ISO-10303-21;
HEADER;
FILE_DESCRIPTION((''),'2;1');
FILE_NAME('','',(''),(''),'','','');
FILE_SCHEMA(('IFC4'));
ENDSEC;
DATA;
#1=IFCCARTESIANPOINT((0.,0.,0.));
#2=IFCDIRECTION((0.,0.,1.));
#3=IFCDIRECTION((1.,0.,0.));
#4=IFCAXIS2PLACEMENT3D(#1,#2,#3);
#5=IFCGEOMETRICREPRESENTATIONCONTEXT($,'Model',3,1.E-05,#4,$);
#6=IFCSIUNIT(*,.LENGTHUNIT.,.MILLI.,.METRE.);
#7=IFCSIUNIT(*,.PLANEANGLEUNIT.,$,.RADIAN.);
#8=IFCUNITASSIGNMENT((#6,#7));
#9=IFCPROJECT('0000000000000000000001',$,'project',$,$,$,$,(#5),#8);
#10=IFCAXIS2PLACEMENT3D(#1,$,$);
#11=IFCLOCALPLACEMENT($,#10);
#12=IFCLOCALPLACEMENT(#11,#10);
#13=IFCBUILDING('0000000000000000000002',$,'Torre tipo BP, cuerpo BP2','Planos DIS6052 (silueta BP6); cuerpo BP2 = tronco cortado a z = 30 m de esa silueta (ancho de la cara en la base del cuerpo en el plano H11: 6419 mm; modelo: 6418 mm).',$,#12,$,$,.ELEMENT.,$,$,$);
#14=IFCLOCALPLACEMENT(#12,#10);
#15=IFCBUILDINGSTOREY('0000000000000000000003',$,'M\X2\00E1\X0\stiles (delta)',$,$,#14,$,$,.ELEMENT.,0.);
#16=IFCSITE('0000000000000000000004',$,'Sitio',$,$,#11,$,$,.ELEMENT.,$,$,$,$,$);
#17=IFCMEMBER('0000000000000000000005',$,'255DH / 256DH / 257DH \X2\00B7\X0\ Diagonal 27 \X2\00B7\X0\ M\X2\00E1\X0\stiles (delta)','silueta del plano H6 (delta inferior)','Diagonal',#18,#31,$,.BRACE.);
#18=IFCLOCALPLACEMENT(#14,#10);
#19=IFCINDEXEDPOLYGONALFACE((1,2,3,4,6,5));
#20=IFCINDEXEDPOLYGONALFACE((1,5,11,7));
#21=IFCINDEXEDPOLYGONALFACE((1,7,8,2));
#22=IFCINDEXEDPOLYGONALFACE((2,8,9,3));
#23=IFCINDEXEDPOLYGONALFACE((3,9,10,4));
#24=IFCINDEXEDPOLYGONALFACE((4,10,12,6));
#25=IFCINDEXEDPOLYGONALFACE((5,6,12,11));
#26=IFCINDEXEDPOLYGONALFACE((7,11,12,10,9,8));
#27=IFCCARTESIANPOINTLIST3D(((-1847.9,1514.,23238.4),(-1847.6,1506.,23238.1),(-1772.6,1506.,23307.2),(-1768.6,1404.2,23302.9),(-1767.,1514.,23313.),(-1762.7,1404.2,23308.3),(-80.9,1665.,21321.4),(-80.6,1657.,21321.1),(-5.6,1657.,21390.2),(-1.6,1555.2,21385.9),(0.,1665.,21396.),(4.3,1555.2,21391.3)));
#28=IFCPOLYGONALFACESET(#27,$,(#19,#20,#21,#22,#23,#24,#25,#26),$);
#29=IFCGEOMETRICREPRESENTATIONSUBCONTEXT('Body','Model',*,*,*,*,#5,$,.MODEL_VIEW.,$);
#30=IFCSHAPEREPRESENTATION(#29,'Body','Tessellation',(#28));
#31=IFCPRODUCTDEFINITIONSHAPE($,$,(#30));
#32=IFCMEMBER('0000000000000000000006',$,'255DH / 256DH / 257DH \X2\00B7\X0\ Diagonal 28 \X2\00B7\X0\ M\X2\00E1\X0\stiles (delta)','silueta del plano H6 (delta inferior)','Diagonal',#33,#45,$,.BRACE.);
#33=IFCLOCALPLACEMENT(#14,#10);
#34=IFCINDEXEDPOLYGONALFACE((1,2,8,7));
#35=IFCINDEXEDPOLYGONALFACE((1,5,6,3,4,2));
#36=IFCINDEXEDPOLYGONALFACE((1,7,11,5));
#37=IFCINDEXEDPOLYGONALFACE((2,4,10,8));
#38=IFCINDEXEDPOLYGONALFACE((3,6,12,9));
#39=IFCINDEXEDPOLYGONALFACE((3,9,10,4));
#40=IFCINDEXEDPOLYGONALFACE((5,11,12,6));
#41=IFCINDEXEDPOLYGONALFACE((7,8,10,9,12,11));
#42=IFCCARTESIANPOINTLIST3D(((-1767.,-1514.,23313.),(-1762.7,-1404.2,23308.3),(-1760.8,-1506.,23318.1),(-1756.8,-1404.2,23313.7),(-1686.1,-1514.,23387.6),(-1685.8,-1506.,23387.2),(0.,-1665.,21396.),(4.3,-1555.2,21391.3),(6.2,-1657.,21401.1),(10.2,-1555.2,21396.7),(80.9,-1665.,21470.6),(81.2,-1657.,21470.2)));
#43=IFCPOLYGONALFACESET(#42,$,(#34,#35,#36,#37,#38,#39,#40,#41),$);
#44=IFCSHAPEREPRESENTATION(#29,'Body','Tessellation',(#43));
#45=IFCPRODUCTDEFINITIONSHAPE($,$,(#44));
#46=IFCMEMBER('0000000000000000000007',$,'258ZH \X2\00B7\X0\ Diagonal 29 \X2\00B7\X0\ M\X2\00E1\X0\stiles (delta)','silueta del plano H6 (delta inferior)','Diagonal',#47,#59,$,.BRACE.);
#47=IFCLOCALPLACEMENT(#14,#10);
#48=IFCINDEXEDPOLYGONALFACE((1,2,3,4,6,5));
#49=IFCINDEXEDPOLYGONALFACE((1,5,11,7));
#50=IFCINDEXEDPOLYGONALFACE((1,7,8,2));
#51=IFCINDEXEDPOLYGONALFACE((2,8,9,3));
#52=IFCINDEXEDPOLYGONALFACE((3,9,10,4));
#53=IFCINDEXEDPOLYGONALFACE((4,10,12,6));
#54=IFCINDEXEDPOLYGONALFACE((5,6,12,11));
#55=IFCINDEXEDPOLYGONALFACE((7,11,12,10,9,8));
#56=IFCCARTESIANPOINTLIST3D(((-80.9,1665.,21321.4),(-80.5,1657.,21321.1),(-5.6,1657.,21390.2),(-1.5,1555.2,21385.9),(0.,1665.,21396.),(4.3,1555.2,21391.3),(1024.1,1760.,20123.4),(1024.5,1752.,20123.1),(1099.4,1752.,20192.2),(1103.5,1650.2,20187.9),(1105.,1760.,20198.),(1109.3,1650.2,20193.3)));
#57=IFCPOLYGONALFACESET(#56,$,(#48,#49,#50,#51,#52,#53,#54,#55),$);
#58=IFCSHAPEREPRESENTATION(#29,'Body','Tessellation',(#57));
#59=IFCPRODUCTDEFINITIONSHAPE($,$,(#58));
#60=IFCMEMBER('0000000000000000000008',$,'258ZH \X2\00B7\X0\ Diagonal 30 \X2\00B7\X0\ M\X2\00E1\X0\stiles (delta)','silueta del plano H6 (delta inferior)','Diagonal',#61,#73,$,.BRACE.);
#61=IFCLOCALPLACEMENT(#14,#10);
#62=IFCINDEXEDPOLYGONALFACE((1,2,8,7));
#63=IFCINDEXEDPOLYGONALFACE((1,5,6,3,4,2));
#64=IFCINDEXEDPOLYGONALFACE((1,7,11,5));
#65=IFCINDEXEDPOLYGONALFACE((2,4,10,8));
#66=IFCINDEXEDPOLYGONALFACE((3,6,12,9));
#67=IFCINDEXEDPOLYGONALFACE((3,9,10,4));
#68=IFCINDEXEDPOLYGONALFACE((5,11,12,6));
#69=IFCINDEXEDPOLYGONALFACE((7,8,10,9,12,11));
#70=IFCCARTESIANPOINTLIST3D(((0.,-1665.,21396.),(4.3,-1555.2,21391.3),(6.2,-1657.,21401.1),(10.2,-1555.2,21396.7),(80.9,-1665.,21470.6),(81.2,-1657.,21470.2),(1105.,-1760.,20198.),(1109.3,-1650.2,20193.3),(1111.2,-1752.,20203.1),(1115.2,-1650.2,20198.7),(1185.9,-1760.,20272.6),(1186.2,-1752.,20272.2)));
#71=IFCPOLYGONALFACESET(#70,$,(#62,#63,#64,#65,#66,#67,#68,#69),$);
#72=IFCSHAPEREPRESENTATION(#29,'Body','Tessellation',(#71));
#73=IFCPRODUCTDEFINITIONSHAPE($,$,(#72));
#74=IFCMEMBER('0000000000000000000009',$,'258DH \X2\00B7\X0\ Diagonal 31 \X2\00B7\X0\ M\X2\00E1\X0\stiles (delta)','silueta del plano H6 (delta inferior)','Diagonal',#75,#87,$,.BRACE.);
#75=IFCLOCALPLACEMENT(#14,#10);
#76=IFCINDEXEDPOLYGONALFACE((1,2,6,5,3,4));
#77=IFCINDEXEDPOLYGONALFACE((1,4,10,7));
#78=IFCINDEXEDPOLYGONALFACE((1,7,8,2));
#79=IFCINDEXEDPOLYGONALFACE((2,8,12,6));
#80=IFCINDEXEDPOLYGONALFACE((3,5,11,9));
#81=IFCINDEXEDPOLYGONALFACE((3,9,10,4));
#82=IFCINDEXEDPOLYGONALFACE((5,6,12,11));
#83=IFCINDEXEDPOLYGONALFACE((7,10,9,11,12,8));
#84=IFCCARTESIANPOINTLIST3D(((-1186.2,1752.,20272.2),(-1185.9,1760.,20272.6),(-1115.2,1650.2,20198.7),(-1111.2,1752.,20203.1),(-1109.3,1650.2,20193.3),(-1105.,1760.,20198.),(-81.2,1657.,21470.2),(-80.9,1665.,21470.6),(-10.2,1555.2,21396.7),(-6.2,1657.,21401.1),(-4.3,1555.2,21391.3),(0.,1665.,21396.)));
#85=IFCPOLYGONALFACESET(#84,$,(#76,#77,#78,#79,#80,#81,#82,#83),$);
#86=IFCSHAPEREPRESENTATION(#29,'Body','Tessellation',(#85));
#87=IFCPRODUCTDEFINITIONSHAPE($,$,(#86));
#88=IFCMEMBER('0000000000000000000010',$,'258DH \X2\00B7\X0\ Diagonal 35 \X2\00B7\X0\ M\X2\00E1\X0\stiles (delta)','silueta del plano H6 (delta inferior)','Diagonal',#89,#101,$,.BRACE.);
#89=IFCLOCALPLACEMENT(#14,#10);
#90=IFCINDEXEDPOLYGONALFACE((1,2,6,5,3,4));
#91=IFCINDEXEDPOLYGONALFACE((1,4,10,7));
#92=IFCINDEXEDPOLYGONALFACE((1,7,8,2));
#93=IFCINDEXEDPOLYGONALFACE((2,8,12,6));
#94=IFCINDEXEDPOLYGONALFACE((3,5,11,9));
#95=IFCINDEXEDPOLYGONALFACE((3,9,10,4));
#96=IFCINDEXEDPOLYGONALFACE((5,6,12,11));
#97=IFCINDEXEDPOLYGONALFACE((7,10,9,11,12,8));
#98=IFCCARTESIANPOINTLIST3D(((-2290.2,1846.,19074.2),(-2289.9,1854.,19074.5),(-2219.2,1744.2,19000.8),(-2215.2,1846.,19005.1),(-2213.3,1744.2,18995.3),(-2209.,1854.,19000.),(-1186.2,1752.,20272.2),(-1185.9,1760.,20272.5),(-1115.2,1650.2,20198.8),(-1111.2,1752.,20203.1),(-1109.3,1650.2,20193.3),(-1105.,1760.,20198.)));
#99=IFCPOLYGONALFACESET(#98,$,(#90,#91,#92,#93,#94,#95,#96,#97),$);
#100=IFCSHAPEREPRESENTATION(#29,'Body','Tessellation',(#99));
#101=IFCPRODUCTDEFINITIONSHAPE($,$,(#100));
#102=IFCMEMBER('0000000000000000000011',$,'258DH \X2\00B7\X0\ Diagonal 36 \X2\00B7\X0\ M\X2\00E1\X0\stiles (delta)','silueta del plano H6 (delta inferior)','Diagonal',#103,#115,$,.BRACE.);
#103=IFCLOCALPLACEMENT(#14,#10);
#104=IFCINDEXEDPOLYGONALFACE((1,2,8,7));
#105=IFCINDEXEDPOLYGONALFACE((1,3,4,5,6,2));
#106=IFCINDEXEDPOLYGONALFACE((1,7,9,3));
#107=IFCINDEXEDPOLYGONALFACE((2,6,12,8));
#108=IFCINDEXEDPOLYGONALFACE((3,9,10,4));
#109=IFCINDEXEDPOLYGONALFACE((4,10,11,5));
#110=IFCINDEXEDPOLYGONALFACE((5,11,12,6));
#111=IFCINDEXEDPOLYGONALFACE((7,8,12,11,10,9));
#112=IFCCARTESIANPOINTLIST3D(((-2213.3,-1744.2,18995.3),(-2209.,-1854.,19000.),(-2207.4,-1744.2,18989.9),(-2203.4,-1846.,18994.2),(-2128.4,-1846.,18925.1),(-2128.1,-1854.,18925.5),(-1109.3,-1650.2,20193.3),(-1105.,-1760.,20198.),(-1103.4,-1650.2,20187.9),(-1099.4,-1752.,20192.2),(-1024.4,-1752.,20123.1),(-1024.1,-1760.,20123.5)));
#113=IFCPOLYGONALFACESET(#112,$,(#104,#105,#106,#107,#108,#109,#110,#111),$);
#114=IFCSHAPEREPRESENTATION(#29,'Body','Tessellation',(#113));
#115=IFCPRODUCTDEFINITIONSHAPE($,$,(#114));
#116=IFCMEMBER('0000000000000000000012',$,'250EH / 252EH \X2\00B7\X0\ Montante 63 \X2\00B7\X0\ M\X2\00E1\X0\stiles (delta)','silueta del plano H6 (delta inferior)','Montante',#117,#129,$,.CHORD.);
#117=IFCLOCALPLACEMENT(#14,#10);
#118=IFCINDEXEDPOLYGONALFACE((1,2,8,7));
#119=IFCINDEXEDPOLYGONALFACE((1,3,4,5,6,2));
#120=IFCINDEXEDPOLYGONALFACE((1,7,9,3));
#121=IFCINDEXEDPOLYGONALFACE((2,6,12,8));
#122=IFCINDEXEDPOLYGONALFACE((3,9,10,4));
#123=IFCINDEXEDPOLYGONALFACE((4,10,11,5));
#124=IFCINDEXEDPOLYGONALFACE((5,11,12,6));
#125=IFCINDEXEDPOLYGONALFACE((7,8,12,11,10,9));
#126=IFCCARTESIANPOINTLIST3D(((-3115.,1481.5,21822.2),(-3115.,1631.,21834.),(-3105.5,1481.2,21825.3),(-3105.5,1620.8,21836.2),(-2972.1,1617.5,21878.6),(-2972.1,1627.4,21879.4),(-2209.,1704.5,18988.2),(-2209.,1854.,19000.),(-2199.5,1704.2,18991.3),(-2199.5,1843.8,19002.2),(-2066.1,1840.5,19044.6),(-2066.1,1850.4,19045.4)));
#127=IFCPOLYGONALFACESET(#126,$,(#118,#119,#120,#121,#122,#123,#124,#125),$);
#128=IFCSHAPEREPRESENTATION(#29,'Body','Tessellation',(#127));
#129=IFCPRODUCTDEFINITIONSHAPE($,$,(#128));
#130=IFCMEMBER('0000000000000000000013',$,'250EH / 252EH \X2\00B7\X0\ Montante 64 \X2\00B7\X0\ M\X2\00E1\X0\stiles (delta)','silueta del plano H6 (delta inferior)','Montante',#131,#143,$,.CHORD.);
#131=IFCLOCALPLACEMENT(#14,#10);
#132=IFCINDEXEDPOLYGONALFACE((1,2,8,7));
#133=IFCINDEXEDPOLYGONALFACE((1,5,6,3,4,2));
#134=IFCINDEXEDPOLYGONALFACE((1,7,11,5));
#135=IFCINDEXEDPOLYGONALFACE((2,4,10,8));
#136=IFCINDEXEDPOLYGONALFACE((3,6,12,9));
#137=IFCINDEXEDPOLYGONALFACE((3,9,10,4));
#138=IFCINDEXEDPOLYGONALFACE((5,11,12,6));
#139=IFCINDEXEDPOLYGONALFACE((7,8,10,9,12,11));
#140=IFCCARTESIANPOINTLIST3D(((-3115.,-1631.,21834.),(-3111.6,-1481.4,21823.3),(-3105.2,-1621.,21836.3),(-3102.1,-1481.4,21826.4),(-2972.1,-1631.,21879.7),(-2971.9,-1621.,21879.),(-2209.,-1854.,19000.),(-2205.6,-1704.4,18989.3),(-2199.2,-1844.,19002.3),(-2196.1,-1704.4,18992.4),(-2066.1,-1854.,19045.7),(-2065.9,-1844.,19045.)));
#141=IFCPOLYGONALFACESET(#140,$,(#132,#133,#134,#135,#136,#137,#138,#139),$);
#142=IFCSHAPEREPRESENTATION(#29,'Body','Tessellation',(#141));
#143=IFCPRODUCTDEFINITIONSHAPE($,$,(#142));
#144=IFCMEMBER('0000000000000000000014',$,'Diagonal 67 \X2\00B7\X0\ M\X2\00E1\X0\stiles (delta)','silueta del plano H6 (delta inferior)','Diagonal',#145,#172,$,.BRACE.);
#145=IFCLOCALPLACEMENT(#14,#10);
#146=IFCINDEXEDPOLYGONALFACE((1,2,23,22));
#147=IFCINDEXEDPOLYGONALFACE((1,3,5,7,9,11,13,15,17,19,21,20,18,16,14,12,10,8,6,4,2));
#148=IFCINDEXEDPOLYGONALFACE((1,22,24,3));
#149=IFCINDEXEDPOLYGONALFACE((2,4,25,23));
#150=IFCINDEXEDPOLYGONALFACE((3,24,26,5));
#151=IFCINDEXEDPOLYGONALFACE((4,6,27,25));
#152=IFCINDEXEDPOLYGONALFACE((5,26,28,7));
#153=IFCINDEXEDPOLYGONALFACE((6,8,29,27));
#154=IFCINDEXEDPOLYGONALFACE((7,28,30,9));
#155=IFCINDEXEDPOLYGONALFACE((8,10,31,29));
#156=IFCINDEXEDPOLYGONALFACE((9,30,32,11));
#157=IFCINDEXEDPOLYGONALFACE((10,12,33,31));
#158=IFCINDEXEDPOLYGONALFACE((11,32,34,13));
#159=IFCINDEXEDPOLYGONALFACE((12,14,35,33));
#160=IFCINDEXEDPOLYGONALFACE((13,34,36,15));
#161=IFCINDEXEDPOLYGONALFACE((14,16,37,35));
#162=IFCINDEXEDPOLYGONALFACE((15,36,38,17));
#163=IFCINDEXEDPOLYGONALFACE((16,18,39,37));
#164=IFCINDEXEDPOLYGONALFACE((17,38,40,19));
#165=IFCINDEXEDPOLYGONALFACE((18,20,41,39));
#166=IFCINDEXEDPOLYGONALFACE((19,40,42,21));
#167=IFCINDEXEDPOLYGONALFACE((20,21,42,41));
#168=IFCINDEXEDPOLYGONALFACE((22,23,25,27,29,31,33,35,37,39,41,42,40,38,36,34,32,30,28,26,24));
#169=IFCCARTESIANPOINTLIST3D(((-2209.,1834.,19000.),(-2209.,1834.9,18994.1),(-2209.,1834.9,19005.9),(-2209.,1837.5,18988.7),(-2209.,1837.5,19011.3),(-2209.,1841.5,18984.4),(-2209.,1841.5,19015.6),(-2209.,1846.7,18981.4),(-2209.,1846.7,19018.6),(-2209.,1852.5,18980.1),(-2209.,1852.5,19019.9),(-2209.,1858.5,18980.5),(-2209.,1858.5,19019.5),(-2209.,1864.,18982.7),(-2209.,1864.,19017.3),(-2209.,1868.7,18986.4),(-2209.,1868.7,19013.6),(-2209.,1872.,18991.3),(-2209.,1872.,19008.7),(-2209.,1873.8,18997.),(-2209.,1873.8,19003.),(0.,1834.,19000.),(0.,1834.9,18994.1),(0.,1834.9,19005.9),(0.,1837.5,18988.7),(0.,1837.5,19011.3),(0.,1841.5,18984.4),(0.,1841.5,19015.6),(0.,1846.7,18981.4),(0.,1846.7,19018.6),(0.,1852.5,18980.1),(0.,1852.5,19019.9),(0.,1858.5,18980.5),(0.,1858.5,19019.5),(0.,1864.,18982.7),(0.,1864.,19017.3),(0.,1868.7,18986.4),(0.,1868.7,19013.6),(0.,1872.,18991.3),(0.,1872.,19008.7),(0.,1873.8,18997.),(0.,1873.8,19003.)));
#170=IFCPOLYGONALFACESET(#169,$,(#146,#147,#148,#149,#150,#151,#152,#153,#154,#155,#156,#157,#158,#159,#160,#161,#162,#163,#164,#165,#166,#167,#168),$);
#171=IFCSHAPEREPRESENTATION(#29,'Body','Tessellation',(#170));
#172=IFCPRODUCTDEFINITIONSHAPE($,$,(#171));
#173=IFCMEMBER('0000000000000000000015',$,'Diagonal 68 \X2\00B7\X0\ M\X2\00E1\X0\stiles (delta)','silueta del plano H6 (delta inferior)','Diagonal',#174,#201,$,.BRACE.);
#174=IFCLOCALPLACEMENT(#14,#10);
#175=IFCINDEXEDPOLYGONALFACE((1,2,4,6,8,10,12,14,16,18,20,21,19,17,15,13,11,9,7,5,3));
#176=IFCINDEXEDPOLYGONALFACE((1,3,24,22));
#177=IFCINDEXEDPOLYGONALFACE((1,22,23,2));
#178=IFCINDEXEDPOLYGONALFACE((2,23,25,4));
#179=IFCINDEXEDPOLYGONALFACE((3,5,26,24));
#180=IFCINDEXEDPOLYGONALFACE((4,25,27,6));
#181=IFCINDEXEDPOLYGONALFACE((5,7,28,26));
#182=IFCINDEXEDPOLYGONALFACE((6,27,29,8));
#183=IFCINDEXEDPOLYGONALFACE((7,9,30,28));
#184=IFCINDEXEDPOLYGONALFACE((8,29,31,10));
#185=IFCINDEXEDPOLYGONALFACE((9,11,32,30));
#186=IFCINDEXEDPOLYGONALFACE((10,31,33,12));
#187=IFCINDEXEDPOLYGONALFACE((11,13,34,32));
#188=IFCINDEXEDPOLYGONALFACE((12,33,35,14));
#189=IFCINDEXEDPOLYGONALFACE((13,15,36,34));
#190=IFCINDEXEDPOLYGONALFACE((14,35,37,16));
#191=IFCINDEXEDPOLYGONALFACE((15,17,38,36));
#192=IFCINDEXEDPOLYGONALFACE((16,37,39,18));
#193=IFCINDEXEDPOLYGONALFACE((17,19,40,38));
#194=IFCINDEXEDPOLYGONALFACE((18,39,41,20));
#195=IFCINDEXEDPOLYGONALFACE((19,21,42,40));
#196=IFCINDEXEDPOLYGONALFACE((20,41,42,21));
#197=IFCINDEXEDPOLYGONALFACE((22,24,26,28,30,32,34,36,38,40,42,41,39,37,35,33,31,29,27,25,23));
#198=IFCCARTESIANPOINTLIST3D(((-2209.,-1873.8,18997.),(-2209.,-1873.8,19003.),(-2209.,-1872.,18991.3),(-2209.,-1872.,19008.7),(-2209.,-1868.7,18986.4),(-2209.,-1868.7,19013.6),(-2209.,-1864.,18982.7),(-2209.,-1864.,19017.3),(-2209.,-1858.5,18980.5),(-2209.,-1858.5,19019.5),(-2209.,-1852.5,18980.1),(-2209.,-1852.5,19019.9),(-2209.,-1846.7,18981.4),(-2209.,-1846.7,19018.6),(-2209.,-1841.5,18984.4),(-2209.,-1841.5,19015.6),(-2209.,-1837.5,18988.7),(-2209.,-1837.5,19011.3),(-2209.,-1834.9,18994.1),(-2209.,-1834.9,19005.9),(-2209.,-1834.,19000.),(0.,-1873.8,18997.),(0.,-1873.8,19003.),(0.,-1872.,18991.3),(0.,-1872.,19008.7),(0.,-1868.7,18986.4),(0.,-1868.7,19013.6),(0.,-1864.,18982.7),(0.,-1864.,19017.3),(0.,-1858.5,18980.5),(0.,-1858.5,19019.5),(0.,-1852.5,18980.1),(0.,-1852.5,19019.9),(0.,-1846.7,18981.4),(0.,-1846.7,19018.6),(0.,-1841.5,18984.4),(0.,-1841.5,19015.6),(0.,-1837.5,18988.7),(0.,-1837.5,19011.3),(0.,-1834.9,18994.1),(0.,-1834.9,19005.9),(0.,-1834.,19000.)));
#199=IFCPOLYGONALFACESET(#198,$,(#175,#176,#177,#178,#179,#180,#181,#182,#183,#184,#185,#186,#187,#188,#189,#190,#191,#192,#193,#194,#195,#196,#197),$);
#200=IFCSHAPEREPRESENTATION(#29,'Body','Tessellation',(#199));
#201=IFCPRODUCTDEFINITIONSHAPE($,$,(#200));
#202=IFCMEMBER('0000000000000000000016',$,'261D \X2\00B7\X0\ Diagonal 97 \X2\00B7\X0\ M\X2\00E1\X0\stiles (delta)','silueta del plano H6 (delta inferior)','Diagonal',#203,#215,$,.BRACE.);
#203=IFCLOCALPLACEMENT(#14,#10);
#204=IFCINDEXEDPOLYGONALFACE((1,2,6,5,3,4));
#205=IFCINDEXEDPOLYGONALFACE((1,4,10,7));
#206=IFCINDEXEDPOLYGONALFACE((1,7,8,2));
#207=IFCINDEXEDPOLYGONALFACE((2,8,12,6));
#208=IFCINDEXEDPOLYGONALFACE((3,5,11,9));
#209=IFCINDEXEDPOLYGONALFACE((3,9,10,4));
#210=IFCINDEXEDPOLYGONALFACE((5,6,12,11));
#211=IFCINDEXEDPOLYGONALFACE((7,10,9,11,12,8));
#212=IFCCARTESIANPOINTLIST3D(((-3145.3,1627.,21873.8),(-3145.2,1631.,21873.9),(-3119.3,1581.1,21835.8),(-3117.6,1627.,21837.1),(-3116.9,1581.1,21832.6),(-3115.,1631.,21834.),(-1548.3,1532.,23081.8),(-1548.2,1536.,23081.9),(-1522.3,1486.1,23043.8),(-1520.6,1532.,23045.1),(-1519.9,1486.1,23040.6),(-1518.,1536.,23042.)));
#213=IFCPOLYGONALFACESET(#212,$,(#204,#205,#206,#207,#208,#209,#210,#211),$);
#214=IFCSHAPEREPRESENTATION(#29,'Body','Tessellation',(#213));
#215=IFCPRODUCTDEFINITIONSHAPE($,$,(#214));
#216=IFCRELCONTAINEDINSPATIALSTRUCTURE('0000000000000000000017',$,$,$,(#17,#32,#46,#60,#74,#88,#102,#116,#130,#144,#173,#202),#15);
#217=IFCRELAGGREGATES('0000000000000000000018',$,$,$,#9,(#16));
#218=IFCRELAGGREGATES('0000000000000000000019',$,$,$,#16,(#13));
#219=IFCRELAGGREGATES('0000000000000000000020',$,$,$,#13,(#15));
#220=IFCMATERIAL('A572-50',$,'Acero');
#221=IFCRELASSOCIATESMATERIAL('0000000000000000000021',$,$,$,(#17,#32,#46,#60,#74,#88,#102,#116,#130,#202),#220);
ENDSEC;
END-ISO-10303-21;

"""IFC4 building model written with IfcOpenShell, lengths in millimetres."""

from ifc_helpers import new_model, si_unit, frame, frame_2d, origin, origin_with_axes, place, context, subcontext, project, spatial, circle, l_section, extrude, material, element, save


model = new_model("IFC4")

# Units and contexts
model_context = context("Model", 3, precision=1e-05, world=origin_with_axes())
body_context = subcontext(model_context, "Body", "Model", "MODEL_VIEW")
ifc_project = project(units=[si_unit("LENGTHUNIT", "METRE", prefix="MILLI"), si_unit("PLANEANGLEUNIT", "RADIAN")], contexts=[model_context])

# Site, building, storey
site_placement = place(None, origin())
site = spatial("IfcSite", under=ifc_project, at=site_placement, Name="Sitio", CompositionType="ELEMENT")
building_placement = place(site_placement, origin())
building = spatial("IfcBuilding", under=site, at=building_placement, Name="Torre tipo BP, cuerpo BP2", Description="Planos DIS6052 (silueta BP6); cuerpo BP2 = tronco cortado a z = 30 m de esa silueta (ancho de la cara en la base del cuerpo en el plano H11: 6419 mm; modelo: 6418 mm).", CompositionType="ELEMENT")
storey_placement = place(building_placement, origin())
storey = spatial("IfcBuildingStorey", under=building, at=storey_placement, Name="Mástiles (delta)", CompositionType="ELEMENT", Elevation=0.0)

# Members
ifc_material = material(Name="A572-50", Category="Acero")
for number, where, z_axis, x_axis, name in (
    (1, (-1767.0, 1514.0, 23313.0), (0.67662, 0.057821, -0.734058), (0.039188, -0.998327, -0.042515), "255DH / 256DH / 257DH · Diagonal 27 · Mástiles (delta)"),
    (2, (-1767.0, -1514.0, 23313.0), (0.67662, -0.057821, -0.734058), (0.039188, 0.998327, -0.042515), "255DH / 256DH / 257DH · Diagonal 28 · Mástiles (delta)"),
):
    element("IfcMember", number, at=place(storey_placement, frame(where, z_axis=z_axis, x_axis=x_axis)), inside=storey, material=ifc_material, Name=name, Description="silueta del plano H6 (delta inferior)", ObjectType="Diagonal", PredefinedType="BRACE", context=body_context, shape_type="SweptSolid", body=[
        extrude(l_section(Depth=110.0, Width=110.0, Thickness=8.0, at=frame_2d((55.0, 55.0))), None, (0.0, 0.0, 1.0), 2611.5),
    ])
for number, where, z_axis, x_axis, name in (
    (3, (0.0, 1665.0, 21396.0), (0.676851, 0.058191, -0.733817), (0.039453, -0.998305, -0.042774), "258ZH · Diagonal 29 · Mástiles (delta)"),
    (4, (0.0, -1665.0, 21396.0), (0.676851, -0.058191, -0.733817), (0.039453, 0.998305, -0.042774), "258ZH · Diagonal 30 · Mástiles (delta)"),
    (5, (0.0, 1665.0, 21396.0), (-0.676851, 0.058191, -0.733817), (-0.039453, -0.998305, -0.042774), "258DH · Diagonal 31 · Mástiles (delta)"),
):
    element("IfcMember", number, at=place(storey_placement, frame(where, z_axis=z_axis, x_axis=x_axis)), inside=storey, material=ifc_material, Name=name, Description="silueta del plano H6 (delta inferior)", ObjectType="Diagonal", PredefinedType="BRACE", context=body_context, shape_type="SweptSolid", body=[
        extrude(l_section(Depth=110.0, Width=110.0, Thickness=8.0, at=frame_2d((55.0, 55.0))), None, (0.0, 0.0, 1.0), 1632.6),
    ])
for number, where, z_axis, x_axis, name in (
    (6, (-1105.0, 1760.0, 20198.0), (-0.676543, 0.057604, -0.734147), (-0.039037, -0.99834, -0.04236), "258DH · Diagonal 35 · Mástiles (delta)"),
    (7, (-1105.0, -1760.0, 20198.0), (-0.676543, -0.057604, -0.734147), (-0.039037, 0.99834, -0.04236), "258DH · Diagonal 36 · Mástiles (delta)"),
):
    element("IfcMember", number, at=place(storey_placement, frame(where, z_axis=z_axis, x_axis=x_axis)), inside=storey, material=ifc_material, Name=name, Description="silueta del plano H6 (delta inferior)", ObjectType="Diagonal", PredefinedType="BRACE", context=body_context, shape_type="SweptSolid", body=[
        extrude(l_section(Depth=110.0, Width=110.0, Thickness=8.0, at=frame_2d((55.0, 55.0))), None, (0.0, 0.0, 1.0), 1631.8),
    ])
for number, where, z_axis, x_axis, name in (
    (8, (-3115.0, 1631.0, 21834.0), (0.303656, 0.074741, -0.949846), (0.952782, -0.02382, 0.30272), "250EH / 252EH · Montante 63 · Mástiles (delta)"),
    (9, (-3115.0, -1631.0, 21834.0), (0.303656, -0.074741, -0.949846), (0.022759, 0.997203, -0.071191), "250EH / 252EH · Montante 64 · Mástiles (delta)"),
):
    element("IfcMember", number, at=place(storey_placement, frame(where, z_axis=z_axis, x_axis=x_axis)), inside=storey, material=ifc_material, Name=name, Description="silueta del plano H6 (delta inferior)", ObjectType="Montante", PredefinedType="CHORD", context=body_context, shape_type="SweptSolid", body=[
        extrude(l_section(Depth=150.0, Width=150.0, Thickness=10.0, at=frame_2d((75.0, 75.0))), None, (0.0, 0.0, 1.0), 2983.6),
    ])
for number, where, z_axis, x_axis, name in (
    (10, (-2209.0, 1854.0, 19000.0), (1.0, 0.0, 0.0), (0.0, -1.0, 0.0), "Diagonal 67 · Mástiles (delta)"),
    (11, (-2209.0, -1854.0, 19000.0), (1.0, 0.0, 0.0), (0.0, 1.0, 0.0), "Diagonal 68 · Mástiles (delta)"),
):
    element("IfcMember", number, at=place(storey_placement, frame(where, z_axis=z_axis, x_axis=x_axis)), inside=storey, Name=name, Description="silueta del plano H6 (delta inferior)", ObjectType="Diagonal", PredefinedType="BRACE", context=body_context, shape_type="SweptSolid", body=[
        extrude(circle(Radius=20.0), None, (0.0, 0.0, 1.0), 2209.0),
    ])
for number, where, z_axis, x_axis, name in (
    (12, (-1518.0, 1536.0, 23042.0), (-0.79664, 0.047389, -0.602593), (-0.037795, -0.998876, -0.028589), "261D · Diagonal 97 · Mástiles (delta)"),
):
    element("IfcMember", number, at=place(storey_placement, frame(where, z_axis=z_axis, x_axis=x_axis)), inside=storey, material=ifc_material, Name=name, Description="silueta del plano H6 (delta inferior)", ObjectType="Diagonal", PredefinedType="BRACE", context=body_context, shape_type="SweptSolid", body=[
        extrude(l_section(Depth=50.0, Width=50.0, Thickness=4.0, at=frame_2d((25.0, 25.0))), None, (0.0, 0.0, 1.0), 2004.7),
    ])

save(model, "model.ifc")
